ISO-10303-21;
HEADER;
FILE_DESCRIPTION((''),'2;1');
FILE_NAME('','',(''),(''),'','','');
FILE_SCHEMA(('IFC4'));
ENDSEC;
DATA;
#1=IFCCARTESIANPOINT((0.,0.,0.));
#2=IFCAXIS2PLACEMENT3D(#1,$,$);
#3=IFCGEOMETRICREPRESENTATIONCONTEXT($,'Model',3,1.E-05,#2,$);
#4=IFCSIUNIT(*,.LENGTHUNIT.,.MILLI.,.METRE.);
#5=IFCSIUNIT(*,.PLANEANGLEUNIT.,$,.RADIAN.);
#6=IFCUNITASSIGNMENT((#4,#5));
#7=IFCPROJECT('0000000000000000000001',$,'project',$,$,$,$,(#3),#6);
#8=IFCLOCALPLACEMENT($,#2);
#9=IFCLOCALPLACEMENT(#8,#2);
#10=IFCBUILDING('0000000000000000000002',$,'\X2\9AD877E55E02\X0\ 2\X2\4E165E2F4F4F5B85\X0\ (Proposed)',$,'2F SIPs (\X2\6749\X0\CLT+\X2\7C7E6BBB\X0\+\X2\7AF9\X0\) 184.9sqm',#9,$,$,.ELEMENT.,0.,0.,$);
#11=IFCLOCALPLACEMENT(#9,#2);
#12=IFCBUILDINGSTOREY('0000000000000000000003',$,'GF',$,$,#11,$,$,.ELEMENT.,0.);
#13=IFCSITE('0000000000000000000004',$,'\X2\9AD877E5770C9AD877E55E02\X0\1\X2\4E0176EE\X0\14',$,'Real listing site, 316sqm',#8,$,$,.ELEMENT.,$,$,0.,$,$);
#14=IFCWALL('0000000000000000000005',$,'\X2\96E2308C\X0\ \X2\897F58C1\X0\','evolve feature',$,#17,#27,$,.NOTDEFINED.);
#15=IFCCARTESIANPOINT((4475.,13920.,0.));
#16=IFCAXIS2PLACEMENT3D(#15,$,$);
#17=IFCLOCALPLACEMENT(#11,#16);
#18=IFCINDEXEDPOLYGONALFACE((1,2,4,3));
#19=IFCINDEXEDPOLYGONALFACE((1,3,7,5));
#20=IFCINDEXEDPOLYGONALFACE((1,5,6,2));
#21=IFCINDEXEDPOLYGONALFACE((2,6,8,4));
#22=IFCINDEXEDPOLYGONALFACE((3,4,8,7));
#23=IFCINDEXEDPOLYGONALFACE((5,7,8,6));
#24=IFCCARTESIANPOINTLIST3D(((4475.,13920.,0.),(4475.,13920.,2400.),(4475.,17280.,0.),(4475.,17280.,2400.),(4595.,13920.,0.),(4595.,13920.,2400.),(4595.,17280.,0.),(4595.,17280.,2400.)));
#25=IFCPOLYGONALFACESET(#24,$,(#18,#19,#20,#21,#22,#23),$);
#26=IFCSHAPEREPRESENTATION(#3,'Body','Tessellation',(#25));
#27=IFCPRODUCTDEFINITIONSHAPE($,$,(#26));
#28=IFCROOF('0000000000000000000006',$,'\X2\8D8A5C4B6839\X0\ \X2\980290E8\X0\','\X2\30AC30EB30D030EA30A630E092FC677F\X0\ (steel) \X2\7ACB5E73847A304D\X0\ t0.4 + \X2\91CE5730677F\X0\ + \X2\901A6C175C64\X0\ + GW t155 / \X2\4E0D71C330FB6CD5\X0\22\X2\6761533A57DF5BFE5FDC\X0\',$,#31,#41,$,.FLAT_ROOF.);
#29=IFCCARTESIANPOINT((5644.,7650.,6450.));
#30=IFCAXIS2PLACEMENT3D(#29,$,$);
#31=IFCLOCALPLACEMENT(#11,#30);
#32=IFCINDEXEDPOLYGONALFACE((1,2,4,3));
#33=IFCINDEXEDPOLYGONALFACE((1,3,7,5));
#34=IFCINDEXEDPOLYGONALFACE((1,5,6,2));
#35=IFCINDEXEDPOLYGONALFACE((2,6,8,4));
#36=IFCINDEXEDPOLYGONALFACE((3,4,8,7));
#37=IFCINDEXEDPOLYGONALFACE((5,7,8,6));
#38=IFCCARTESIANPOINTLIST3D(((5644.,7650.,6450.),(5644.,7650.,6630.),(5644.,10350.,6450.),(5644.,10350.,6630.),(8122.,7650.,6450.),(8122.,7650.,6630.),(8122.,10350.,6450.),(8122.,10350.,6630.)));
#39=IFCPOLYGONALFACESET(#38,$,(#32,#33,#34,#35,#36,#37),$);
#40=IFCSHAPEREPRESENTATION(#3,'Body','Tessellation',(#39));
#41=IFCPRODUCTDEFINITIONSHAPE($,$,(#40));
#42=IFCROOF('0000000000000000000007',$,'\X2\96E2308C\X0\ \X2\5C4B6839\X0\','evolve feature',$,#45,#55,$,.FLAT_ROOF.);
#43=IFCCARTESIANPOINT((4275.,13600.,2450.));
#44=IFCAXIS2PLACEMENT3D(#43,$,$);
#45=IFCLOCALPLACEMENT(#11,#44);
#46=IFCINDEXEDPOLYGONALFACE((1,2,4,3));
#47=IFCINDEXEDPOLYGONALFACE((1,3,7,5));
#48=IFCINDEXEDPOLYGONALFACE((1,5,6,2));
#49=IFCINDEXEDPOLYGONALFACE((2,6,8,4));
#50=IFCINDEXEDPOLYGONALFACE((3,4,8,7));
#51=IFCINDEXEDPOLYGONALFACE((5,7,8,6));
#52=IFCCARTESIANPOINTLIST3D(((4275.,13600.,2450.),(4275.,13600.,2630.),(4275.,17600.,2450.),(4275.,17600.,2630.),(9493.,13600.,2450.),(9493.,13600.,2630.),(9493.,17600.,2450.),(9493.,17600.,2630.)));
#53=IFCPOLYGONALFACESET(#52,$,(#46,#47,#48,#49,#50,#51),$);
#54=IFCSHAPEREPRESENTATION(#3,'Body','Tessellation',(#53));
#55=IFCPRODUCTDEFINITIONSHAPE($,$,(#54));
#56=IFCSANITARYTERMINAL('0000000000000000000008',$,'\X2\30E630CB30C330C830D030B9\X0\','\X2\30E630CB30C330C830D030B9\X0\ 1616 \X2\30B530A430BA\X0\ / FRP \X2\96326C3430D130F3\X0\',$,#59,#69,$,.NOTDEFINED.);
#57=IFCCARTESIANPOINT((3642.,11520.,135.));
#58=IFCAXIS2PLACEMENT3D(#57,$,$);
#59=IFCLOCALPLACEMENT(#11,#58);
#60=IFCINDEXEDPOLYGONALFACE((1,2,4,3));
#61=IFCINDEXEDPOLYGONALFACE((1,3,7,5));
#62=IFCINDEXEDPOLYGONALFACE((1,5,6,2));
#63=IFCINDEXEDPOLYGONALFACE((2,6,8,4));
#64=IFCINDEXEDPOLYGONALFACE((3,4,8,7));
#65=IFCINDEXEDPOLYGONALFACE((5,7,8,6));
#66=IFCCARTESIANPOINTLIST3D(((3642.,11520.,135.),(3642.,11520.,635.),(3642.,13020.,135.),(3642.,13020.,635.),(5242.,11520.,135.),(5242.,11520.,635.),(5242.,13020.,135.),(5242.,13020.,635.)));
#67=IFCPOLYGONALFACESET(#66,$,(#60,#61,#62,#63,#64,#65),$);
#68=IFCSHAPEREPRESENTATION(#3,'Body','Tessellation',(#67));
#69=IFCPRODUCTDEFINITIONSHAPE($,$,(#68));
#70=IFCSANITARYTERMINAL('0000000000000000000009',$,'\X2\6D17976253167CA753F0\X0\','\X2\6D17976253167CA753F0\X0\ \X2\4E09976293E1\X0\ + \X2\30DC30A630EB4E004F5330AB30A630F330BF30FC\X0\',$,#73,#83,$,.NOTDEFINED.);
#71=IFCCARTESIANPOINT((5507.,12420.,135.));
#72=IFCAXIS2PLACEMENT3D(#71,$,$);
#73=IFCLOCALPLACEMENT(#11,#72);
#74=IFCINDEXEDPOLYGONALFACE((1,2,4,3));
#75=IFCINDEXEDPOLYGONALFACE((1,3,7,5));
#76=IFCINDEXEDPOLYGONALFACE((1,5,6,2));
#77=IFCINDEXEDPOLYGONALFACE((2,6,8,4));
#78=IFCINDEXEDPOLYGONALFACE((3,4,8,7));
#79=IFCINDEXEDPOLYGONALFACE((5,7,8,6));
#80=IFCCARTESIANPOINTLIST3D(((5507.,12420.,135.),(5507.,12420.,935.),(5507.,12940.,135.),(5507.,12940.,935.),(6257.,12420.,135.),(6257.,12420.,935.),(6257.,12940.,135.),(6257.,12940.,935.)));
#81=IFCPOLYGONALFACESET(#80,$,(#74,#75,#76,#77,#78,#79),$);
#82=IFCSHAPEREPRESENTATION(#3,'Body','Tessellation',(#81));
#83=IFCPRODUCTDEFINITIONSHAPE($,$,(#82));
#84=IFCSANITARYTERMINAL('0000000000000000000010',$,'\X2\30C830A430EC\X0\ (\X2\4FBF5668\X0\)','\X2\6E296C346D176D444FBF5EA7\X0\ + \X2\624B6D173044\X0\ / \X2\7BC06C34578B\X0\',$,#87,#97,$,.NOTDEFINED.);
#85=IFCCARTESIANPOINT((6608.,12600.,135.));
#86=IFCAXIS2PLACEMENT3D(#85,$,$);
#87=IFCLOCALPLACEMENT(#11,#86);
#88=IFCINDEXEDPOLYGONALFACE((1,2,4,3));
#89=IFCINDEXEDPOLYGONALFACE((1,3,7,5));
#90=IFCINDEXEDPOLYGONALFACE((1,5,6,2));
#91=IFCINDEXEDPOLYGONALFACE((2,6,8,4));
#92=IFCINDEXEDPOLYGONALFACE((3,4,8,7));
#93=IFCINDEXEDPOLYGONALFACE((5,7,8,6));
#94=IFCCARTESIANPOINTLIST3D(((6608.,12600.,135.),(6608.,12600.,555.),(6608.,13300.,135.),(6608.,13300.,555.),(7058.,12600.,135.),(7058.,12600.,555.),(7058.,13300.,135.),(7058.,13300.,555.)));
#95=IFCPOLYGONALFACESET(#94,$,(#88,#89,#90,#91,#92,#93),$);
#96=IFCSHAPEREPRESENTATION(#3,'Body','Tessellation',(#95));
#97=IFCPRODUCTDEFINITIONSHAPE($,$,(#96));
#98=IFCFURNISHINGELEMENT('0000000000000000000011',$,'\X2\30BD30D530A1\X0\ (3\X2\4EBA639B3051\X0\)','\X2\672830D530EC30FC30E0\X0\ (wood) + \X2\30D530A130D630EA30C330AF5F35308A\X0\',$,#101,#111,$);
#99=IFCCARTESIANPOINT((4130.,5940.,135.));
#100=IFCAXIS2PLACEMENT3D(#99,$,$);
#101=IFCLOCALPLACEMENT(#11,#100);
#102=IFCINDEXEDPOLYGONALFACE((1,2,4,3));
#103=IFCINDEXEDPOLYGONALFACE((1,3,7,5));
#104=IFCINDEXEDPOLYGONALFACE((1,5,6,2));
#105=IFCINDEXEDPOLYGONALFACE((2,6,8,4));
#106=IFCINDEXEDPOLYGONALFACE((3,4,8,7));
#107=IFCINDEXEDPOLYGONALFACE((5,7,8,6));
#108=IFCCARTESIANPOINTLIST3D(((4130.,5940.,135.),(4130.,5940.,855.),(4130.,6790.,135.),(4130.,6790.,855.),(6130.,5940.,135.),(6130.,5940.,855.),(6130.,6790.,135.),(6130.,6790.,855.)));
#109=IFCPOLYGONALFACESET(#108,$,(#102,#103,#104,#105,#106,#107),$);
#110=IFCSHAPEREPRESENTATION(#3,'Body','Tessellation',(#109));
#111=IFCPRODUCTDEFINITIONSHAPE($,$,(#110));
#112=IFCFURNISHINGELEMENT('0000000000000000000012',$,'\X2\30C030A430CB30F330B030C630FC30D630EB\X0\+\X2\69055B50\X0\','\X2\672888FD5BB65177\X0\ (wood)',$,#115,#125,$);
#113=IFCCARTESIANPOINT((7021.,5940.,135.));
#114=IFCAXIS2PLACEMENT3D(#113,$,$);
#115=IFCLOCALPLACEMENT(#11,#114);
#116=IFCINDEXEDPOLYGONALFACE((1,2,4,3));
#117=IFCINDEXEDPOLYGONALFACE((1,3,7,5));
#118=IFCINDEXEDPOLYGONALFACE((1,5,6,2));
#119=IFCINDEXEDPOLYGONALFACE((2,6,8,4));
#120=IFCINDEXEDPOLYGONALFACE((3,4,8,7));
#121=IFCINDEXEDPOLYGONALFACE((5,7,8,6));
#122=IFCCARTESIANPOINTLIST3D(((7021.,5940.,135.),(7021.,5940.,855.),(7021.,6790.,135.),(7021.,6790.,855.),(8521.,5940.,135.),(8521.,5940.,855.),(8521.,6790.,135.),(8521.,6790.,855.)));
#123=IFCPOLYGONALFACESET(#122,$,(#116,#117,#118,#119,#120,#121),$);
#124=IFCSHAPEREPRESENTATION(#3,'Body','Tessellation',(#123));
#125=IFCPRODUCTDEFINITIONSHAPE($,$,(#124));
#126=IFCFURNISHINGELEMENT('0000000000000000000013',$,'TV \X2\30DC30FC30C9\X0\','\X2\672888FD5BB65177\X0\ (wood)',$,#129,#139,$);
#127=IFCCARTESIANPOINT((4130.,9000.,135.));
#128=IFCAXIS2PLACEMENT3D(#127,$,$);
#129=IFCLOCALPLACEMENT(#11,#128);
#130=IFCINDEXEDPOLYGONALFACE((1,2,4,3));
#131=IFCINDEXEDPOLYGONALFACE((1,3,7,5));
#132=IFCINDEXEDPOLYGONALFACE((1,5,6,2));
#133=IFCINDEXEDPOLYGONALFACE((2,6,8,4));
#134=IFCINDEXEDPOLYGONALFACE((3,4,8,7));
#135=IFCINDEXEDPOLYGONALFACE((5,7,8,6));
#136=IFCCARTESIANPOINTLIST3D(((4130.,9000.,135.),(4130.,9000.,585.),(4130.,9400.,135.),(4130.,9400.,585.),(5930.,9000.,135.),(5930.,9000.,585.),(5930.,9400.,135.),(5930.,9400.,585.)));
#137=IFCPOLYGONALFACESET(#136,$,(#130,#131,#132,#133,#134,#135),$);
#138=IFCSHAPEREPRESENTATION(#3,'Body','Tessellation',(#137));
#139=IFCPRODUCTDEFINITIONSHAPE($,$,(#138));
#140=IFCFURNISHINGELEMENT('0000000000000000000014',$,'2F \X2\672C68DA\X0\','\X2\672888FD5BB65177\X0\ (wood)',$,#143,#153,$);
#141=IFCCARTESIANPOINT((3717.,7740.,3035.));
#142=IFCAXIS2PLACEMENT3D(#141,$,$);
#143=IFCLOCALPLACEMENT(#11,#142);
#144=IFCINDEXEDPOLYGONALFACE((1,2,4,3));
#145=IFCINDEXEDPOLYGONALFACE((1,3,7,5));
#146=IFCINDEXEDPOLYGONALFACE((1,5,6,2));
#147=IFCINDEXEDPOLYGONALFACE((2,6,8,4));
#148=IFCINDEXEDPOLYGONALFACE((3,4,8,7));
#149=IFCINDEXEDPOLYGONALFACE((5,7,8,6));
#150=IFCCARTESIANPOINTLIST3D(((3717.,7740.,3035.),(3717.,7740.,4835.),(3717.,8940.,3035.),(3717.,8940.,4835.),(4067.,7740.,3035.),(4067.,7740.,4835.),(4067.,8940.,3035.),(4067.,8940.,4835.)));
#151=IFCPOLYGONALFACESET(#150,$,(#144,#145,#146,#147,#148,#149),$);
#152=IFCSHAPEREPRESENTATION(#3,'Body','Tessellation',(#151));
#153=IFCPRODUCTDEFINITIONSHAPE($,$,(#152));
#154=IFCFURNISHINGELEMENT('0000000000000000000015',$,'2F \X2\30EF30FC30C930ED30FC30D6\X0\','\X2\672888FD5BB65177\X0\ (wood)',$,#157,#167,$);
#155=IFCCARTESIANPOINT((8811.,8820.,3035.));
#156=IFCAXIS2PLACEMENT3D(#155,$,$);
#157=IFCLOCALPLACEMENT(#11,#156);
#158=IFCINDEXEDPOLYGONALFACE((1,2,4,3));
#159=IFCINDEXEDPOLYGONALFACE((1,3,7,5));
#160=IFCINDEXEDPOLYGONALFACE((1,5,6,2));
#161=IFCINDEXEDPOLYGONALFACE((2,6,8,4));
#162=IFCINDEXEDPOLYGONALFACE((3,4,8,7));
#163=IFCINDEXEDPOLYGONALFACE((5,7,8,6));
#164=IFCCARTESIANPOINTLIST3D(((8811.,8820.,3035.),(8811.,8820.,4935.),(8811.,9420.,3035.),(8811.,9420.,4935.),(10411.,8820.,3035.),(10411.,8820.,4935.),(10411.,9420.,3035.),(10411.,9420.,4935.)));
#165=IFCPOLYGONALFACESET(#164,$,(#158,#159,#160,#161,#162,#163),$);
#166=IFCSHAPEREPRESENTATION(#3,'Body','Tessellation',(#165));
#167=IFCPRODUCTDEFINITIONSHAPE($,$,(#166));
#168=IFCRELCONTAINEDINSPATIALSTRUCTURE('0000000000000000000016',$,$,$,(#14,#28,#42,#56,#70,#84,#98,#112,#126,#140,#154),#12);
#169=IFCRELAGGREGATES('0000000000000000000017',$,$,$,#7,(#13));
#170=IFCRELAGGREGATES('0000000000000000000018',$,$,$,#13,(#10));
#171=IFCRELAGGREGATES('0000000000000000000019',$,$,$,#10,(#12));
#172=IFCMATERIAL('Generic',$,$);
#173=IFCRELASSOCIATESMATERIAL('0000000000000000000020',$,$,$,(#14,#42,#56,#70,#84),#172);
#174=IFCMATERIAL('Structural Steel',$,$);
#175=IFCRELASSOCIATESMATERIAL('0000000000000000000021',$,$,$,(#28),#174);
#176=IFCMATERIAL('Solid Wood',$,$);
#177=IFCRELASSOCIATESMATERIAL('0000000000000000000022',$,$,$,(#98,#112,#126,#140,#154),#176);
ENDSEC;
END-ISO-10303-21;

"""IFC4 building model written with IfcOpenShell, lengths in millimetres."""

from ifc_helpers import new_model, si_unit, frame, frame_2d, origin, place, context, project, spatial, rectangle, extrude, material, element, save


model = new_model("IFC4")

# Units and contexts
model_context = context("Model", 3, precision=1e-05, world=origin())
ifc_project = project(units=[si_unit("LENGTHUNIT", "METRE", prefix="MILLI"), si_unit("PLANEANGLEUNIT", "RADIAN")], contexts=[model_context])

# Site, building, storey
site_placement = place(None, origin())
site = spatial("IfcSite", under=ifc_project, at=site_placement, Name="高知県高知市1丁目14", ObjectType="Real listing site, 316sqm", CompositionType="ELEMENT", RefElevation=0.0)
building_placement = place(site_placement, origin())
building = spatial("IfcBuilding", under=site, at=building_placement, Name="高知市 2世帯住宅 (Proposed)", ObjectType="2F SIPs (杉CLT+籾殻+竹) 184.9sqm", CompositionType="ELEMENT", ElevationOfRefHeight=0.0, ElevationOfTerrain=0.0)
storey_placement = place(building_placement, origin())
storey = spatial("IfcBuildingStorey", under=building, at=storey_placement, Name="GF", CompositionType="ELEMENT", Elevation=0.0)

# Shared definitions
ifc_material_1 = material(Name="Generic")

# Shared definitions
ifc_material_2 = material(Name="Solid Wood")

# Wall
wall_1_placement = place(storey_placement, frame((4475.0, 13920.0, 0.0)))
element("IfcWall", 1, at=wall_1_placement, inside=storey, material=ifc_material_1, Name="離れ 西壁", Description="evolve feature", PredefinedType="NOTDEFINED", context=model_context, shape_type="SweptSolid", body=[
    extrude(rectangle(XDim=120.0, YDim=3360.0, at=frame_2d((60.0, 1680.0))), frame((4475.0, 13920.0, 0.0)), (0.0, 0.0, 1.0), 2400.0),
])

# Roofs
ifc_material_3 = material(Name="Structural Steel")
roof_1_placement = place(storey_placement, frame((5644.0, 7650.0, 6450.0)))
element("IfcRoof", 2, at=roof_1_placement, inside=storey, material=ifc_material_3, Name="越屋根 頂部", Description="ガルバリウム鋼板 (steel) 立平葺き t0.4 + 野地板 + 通気層 + GW t155 / 不燃・法22条区域対応", PredefinedType="FLAT_ROOF", context=model_context, shape_type="SweptSolid", body=[
    extrude(rectangle(XDim=2478.0, YDim=2700.0, at=frame_2d((1239.0, 1350.0))), frame((5644.0, 7650.0, 6450.0)), (0.0, 0.0, 1.0), 180.0),
])
roof_2_placement = place(storey_placement, frame((4275.0, 13600.0, 2450.0)))
element("IfcRoof", 3, at=roof_2_placement, inside=storey, material=ifc_material_1, Name="離れ 屋根", Description="evolve feature", PredefinedType="FLAT_ROOF", context=model_context, shape_type="SweptSolid", body=[
    extrude(rectangle(XDim=5218.0, YDim=4000.0, at=frame_2d((2609.0, 2000.0))), frame((4275.0, 13600.0, 2450.0)), (0.0, 0.0, 1.0), 180.0),
])

# Sanitary terminals
sanitary_terminal_1_placement = place(storey_placement, frame((3642.0, 11520.0, 135.0)))
element("IfcSanitaryTerminal", 4, at=sanitary_terminal_1_placement, inside=storey, material=ifc_material_1, Name="ユニットバス", Description="ユニットバス 1616 サイズ / FRP 防水パン", PredefinedType="NOTDEFINED", context=model_context, shape_type="SweptSolid", body=[
    extrude(rectangle(XDim=1600.0, YDim=1500.0, at=frame_2d((800.0, 750.0))), frame((3642.0, 11520.0, 135.0)), (0.0, 0.0, 1.0), 500.0),
])
sanitary_terminal_2_placement = place(storey_placement, frame((5507.0, 12420.0, 135.0)))
element("IfcSanitaryTerminal", 5, at=sanitary_terminal_2_placement, inside=storey, material=ifc_material_1, Name="洗面化粧台", Description="洗面化粧台 三面鏡 + ボウル一体カウンター", PredefinedType="NOTDEFINED", context=model_context, shape_type="SweptSolid", body=[
    extrude(rectangle(XDim=750.0, YDim=520.0, at=frame_2d((375.0, 260.0))), frame((5507.0, 12420.0, 135.0)), (0.0, 0.0, 1.0), 800.0),
])
sanitary_terminal_3_placement = place(storey_placement, frame((6608.0, 12600.0, 135.0)))
element("IfcSanitaryTerminal", 6, at=sanitary_terminal_3_placement, inside=storey, material=ifc_material_1, Name="トイレ (便器)", Description="温水洗浄便座 + 手洗い / 節水型", PredefinedType="NOTDEFINED", context=model_context, shape_type="SweptSolid", body=[
    extrude(rectangle(XDim=450.0, YDim=700.0, at=frame_2d((225.0, 350.0))), frame((6608.0, 12600.0, 135.0)), (0.0, 0.0, 1.0), 420.0),
])

# Furnishing elements
furnishing_1_placement = place(storey_placement, frame((4130.0, 5940.0, 135.0)))
element("IfcFurnishingElement", 7, at=furnishing_1_placement, inside=storey, material=ifc_material_2, Name="ソファ (3人掛け)", Description="木フレーム (wood) + ファブリック張り", context=model_context, shape_type="SweptSolid", body=[
    extrude(rectangle(XDim=2000.0, YDim=850.0, at=frame_2d((1000.0, 425.0))), frame((4130.0, 5940.0, 135.0)), (0.0, 0.0, 1.0), 720.0),
])
furnishing_2_placement = place(storey_placement, frame((7021.0, 5940.0, 135.0)))
element("IfcFurnishingElement", 8, at=furnishing_2_placement, inside=storey, material=ifc_material_2, Name="ダイニングテーブル+椅子", Description="木製家具 (wood)", context=model_context, shape_type="SweptSolid", body=[
    extrude(rectangle(XDim=1500.0, YDim=850.0, at=frame_2d((750.0, 425.0))), frame((7021.0, 5940.0, 135.0)), (0.0, 0.0, 1.0), 720.0),
])
furnishing_3_placement = place(storey_placement, frame((4130.0, 9000.0, 135.0)))
element("IfcFurnishingElement", 9, at=furnishing_3_placement, inside=storey, material=ifc_material_2, Name="TV ボード", Description="木製家具 (wood)", context=model_context, shape_type="SweptSolid", body=[
    extrude(rectangle(XDim=1800.0, YDim=400.0, at=frame_2d((900.0, 200.0))), frame((4130.0, 9000.0, 135.0)), (0.0, 0.0, 1.0), 450.0),
])
furnishing_4_placement = place(storey_placement, frame((3717.0, 7740.0, 3035.0)))
element("IfcFurnishingElement", 10, at=furnishing_4_placement, inside=storey, material=ifc_material_2, Name="2F 本棚", Description="木製家具 (wood)", context=model_context, shape_type="SweptSolid", body=[
    extrude(rectangle(XDim=350.0, YDim=1200.0, at=frame_2d((175.0, 600.0))), frame((3717.0, 7740.0, 3035.0)), (0.0, 0.0, 1.0), 1800.0),
])
furnishing_5_placement = place(storey_placement, frame((8811.0, 8820.0, 3035.0)))
element("IfcFurnishingElement", 11, at=furnishing_5_placement, inside=storey, material=ifc_material_2, Name="2F ワードローブ", Description="木製家具 (wood)", context=model_context, shape_type="SweptSolid", body=[
    extrude(rectangle(XDim=1600.0, YDim=600.0, at=frame_2d((800.0, 300.0))), frame((8811.0, 8820.0, 3035.0)), (0.0, 0.0, 1.0), 1900.0),
])

save(model, "model.ifc")
